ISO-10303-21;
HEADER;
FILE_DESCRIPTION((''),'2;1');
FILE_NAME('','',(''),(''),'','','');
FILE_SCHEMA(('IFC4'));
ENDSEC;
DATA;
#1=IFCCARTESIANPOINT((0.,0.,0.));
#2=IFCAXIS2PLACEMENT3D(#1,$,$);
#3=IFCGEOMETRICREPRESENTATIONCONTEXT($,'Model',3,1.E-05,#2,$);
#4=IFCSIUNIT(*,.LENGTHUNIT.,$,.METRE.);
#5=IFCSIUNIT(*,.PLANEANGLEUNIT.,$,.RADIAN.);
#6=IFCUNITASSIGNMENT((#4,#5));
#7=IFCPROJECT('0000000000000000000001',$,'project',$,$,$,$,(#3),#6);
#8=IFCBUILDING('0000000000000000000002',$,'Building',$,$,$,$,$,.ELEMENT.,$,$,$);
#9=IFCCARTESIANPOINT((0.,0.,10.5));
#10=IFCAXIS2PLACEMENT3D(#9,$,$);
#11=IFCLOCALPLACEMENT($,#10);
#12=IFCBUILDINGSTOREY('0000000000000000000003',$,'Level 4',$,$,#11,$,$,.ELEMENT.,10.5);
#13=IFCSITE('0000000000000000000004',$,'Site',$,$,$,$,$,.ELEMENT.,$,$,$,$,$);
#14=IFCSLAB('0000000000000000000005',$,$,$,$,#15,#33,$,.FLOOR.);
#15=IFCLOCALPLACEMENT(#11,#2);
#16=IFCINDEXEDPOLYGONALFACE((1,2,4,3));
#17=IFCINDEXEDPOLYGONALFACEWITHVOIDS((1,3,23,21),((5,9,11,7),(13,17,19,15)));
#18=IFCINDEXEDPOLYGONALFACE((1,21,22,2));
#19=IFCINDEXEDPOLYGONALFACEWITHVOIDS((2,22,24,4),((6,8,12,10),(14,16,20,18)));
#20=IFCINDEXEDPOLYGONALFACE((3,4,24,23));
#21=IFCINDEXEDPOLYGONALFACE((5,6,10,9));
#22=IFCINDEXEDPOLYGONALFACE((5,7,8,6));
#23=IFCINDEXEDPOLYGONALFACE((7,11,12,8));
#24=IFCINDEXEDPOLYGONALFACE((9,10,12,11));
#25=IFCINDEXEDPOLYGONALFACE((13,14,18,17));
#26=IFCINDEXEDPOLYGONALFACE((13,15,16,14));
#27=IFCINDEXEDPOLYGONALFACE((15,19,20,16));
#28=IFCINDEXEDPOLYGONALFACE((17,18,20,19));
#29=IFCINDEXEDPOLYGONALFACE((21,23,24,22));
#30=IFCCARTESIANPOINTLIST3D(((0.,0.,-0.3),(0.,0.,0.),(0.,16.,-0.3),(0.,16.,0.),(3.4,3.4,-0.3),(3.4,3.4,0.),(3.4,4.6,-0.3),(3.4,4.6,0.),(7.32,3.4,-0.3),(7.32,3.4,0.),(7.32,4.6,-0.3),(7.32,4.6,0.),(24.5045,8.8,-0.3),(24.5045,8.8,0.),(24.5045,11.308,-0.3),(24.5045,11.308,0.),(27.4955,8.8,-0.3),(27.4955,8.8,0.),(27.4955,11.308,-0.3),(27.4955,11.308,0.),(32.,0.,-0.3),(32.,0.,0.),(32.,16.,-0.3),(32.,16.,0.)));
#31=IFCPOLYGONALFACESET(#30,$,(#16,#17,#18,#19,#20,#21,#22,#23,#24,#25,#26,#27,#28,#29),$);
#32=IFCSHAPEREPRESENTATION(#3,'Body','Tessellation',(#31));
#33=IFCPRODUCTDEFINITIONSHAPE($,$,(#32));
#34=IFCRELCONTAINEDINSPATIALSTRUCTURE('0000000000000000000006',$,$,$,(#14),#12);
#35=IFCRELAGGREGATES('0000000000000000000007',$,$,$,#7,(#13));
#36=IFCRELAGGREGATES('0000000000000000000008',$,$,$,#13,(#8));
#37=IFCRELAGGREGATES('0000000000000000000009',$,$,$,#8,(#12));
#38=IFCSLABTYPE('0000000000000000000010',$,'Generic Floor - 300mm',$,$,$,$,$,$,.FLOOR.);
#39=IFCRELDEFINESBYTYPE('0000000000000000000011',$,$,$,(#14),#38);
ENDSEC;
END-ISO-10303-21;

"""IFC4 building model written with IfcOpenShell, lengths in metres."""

from ifc_helpers import new_model, si_unit, frame, origin, place, context, project, spatial, polyline, outline, extrude, type_object, element, save


model = new_model("IFC4")

# Units and contexts
model_context = context("Model", 3, precision=1e-05, world=origin())
ifc_project = project(units=[si_unit("LENGTHUNIT", "METRE"), si_unit("PLANEANGLEUNIT", "RADIAN")], contexts=[model_context])

# Site, building, storey
site = spatial("IfcSite", under=ifc_project, Name="Site", CompositionType="ELEMENT")
building = spatial("IfcBuilding", under=site, Name="Building", CompositionType="ELEMENT")
storey_placement = place(None, frame((0.0, 0.0, 10.5)))
storey = spatial("IfcBuildingStorey", under=building, at=storey_placement, Name="Level 4", CompositionType="ELEMENT", Elevation=10.5)

# Slab, openings
slab_type = type_object("IfcSlabType", Name="Generic Floor - 300mm", PredefinedType="FLOOR")
slab_placement = place(None, frame((0.0, 0.0, 10.5)))
slab = element("IfcSlab", 1, at=slab_placement, inside=storey, type_object=slab_type, PredefinedType="FLOOR", context=model_context, shape_type="SweptSolid", body=[
    extrude(outline(polyline([(0.0, 0.0), (32.0, 0.0), (32.0, 16.0), (0.0, 16.0), (0.0, 0.0)])), origin(), (0.0, 0.0, -1.0), 0.3),
])
opening_1_placement = place(None, frame((0.0, 0.0, 10.501)))
element("IfcOpeningElement", 2, at=opening_1_placement, cuts=slab, PredefinedType="OPENING", context=model_context, shape_type="SweptSolid", body=[
    extrude(outline(polyline([(3.4, 4.6), (3.4, 3.4), (7.32, 3.4), (7.32, 4.6), (3.4, 4.6)])), origin(), (0.0, 0.0, -1.0), 0.302),
])
opening_2_placement = place(None, frame((0.0, 0.0, 10.501)))
element("IfcOpeningElement", 3, at=opening_2_placement, cuts=slab, PredefinedType="OPENING", context=model_context, shape_type="SweptSolid", body=[
    extrude(outline(polyline([(24.5045, 8.8), (27.4955, 8.8), (27.4955, 11.308), (24.5045, 11.308), (24.5045, 8.8)])), origin(), (0.0, 0.0, -1.0), 0.302),
])

save(model, "model.ifc")
